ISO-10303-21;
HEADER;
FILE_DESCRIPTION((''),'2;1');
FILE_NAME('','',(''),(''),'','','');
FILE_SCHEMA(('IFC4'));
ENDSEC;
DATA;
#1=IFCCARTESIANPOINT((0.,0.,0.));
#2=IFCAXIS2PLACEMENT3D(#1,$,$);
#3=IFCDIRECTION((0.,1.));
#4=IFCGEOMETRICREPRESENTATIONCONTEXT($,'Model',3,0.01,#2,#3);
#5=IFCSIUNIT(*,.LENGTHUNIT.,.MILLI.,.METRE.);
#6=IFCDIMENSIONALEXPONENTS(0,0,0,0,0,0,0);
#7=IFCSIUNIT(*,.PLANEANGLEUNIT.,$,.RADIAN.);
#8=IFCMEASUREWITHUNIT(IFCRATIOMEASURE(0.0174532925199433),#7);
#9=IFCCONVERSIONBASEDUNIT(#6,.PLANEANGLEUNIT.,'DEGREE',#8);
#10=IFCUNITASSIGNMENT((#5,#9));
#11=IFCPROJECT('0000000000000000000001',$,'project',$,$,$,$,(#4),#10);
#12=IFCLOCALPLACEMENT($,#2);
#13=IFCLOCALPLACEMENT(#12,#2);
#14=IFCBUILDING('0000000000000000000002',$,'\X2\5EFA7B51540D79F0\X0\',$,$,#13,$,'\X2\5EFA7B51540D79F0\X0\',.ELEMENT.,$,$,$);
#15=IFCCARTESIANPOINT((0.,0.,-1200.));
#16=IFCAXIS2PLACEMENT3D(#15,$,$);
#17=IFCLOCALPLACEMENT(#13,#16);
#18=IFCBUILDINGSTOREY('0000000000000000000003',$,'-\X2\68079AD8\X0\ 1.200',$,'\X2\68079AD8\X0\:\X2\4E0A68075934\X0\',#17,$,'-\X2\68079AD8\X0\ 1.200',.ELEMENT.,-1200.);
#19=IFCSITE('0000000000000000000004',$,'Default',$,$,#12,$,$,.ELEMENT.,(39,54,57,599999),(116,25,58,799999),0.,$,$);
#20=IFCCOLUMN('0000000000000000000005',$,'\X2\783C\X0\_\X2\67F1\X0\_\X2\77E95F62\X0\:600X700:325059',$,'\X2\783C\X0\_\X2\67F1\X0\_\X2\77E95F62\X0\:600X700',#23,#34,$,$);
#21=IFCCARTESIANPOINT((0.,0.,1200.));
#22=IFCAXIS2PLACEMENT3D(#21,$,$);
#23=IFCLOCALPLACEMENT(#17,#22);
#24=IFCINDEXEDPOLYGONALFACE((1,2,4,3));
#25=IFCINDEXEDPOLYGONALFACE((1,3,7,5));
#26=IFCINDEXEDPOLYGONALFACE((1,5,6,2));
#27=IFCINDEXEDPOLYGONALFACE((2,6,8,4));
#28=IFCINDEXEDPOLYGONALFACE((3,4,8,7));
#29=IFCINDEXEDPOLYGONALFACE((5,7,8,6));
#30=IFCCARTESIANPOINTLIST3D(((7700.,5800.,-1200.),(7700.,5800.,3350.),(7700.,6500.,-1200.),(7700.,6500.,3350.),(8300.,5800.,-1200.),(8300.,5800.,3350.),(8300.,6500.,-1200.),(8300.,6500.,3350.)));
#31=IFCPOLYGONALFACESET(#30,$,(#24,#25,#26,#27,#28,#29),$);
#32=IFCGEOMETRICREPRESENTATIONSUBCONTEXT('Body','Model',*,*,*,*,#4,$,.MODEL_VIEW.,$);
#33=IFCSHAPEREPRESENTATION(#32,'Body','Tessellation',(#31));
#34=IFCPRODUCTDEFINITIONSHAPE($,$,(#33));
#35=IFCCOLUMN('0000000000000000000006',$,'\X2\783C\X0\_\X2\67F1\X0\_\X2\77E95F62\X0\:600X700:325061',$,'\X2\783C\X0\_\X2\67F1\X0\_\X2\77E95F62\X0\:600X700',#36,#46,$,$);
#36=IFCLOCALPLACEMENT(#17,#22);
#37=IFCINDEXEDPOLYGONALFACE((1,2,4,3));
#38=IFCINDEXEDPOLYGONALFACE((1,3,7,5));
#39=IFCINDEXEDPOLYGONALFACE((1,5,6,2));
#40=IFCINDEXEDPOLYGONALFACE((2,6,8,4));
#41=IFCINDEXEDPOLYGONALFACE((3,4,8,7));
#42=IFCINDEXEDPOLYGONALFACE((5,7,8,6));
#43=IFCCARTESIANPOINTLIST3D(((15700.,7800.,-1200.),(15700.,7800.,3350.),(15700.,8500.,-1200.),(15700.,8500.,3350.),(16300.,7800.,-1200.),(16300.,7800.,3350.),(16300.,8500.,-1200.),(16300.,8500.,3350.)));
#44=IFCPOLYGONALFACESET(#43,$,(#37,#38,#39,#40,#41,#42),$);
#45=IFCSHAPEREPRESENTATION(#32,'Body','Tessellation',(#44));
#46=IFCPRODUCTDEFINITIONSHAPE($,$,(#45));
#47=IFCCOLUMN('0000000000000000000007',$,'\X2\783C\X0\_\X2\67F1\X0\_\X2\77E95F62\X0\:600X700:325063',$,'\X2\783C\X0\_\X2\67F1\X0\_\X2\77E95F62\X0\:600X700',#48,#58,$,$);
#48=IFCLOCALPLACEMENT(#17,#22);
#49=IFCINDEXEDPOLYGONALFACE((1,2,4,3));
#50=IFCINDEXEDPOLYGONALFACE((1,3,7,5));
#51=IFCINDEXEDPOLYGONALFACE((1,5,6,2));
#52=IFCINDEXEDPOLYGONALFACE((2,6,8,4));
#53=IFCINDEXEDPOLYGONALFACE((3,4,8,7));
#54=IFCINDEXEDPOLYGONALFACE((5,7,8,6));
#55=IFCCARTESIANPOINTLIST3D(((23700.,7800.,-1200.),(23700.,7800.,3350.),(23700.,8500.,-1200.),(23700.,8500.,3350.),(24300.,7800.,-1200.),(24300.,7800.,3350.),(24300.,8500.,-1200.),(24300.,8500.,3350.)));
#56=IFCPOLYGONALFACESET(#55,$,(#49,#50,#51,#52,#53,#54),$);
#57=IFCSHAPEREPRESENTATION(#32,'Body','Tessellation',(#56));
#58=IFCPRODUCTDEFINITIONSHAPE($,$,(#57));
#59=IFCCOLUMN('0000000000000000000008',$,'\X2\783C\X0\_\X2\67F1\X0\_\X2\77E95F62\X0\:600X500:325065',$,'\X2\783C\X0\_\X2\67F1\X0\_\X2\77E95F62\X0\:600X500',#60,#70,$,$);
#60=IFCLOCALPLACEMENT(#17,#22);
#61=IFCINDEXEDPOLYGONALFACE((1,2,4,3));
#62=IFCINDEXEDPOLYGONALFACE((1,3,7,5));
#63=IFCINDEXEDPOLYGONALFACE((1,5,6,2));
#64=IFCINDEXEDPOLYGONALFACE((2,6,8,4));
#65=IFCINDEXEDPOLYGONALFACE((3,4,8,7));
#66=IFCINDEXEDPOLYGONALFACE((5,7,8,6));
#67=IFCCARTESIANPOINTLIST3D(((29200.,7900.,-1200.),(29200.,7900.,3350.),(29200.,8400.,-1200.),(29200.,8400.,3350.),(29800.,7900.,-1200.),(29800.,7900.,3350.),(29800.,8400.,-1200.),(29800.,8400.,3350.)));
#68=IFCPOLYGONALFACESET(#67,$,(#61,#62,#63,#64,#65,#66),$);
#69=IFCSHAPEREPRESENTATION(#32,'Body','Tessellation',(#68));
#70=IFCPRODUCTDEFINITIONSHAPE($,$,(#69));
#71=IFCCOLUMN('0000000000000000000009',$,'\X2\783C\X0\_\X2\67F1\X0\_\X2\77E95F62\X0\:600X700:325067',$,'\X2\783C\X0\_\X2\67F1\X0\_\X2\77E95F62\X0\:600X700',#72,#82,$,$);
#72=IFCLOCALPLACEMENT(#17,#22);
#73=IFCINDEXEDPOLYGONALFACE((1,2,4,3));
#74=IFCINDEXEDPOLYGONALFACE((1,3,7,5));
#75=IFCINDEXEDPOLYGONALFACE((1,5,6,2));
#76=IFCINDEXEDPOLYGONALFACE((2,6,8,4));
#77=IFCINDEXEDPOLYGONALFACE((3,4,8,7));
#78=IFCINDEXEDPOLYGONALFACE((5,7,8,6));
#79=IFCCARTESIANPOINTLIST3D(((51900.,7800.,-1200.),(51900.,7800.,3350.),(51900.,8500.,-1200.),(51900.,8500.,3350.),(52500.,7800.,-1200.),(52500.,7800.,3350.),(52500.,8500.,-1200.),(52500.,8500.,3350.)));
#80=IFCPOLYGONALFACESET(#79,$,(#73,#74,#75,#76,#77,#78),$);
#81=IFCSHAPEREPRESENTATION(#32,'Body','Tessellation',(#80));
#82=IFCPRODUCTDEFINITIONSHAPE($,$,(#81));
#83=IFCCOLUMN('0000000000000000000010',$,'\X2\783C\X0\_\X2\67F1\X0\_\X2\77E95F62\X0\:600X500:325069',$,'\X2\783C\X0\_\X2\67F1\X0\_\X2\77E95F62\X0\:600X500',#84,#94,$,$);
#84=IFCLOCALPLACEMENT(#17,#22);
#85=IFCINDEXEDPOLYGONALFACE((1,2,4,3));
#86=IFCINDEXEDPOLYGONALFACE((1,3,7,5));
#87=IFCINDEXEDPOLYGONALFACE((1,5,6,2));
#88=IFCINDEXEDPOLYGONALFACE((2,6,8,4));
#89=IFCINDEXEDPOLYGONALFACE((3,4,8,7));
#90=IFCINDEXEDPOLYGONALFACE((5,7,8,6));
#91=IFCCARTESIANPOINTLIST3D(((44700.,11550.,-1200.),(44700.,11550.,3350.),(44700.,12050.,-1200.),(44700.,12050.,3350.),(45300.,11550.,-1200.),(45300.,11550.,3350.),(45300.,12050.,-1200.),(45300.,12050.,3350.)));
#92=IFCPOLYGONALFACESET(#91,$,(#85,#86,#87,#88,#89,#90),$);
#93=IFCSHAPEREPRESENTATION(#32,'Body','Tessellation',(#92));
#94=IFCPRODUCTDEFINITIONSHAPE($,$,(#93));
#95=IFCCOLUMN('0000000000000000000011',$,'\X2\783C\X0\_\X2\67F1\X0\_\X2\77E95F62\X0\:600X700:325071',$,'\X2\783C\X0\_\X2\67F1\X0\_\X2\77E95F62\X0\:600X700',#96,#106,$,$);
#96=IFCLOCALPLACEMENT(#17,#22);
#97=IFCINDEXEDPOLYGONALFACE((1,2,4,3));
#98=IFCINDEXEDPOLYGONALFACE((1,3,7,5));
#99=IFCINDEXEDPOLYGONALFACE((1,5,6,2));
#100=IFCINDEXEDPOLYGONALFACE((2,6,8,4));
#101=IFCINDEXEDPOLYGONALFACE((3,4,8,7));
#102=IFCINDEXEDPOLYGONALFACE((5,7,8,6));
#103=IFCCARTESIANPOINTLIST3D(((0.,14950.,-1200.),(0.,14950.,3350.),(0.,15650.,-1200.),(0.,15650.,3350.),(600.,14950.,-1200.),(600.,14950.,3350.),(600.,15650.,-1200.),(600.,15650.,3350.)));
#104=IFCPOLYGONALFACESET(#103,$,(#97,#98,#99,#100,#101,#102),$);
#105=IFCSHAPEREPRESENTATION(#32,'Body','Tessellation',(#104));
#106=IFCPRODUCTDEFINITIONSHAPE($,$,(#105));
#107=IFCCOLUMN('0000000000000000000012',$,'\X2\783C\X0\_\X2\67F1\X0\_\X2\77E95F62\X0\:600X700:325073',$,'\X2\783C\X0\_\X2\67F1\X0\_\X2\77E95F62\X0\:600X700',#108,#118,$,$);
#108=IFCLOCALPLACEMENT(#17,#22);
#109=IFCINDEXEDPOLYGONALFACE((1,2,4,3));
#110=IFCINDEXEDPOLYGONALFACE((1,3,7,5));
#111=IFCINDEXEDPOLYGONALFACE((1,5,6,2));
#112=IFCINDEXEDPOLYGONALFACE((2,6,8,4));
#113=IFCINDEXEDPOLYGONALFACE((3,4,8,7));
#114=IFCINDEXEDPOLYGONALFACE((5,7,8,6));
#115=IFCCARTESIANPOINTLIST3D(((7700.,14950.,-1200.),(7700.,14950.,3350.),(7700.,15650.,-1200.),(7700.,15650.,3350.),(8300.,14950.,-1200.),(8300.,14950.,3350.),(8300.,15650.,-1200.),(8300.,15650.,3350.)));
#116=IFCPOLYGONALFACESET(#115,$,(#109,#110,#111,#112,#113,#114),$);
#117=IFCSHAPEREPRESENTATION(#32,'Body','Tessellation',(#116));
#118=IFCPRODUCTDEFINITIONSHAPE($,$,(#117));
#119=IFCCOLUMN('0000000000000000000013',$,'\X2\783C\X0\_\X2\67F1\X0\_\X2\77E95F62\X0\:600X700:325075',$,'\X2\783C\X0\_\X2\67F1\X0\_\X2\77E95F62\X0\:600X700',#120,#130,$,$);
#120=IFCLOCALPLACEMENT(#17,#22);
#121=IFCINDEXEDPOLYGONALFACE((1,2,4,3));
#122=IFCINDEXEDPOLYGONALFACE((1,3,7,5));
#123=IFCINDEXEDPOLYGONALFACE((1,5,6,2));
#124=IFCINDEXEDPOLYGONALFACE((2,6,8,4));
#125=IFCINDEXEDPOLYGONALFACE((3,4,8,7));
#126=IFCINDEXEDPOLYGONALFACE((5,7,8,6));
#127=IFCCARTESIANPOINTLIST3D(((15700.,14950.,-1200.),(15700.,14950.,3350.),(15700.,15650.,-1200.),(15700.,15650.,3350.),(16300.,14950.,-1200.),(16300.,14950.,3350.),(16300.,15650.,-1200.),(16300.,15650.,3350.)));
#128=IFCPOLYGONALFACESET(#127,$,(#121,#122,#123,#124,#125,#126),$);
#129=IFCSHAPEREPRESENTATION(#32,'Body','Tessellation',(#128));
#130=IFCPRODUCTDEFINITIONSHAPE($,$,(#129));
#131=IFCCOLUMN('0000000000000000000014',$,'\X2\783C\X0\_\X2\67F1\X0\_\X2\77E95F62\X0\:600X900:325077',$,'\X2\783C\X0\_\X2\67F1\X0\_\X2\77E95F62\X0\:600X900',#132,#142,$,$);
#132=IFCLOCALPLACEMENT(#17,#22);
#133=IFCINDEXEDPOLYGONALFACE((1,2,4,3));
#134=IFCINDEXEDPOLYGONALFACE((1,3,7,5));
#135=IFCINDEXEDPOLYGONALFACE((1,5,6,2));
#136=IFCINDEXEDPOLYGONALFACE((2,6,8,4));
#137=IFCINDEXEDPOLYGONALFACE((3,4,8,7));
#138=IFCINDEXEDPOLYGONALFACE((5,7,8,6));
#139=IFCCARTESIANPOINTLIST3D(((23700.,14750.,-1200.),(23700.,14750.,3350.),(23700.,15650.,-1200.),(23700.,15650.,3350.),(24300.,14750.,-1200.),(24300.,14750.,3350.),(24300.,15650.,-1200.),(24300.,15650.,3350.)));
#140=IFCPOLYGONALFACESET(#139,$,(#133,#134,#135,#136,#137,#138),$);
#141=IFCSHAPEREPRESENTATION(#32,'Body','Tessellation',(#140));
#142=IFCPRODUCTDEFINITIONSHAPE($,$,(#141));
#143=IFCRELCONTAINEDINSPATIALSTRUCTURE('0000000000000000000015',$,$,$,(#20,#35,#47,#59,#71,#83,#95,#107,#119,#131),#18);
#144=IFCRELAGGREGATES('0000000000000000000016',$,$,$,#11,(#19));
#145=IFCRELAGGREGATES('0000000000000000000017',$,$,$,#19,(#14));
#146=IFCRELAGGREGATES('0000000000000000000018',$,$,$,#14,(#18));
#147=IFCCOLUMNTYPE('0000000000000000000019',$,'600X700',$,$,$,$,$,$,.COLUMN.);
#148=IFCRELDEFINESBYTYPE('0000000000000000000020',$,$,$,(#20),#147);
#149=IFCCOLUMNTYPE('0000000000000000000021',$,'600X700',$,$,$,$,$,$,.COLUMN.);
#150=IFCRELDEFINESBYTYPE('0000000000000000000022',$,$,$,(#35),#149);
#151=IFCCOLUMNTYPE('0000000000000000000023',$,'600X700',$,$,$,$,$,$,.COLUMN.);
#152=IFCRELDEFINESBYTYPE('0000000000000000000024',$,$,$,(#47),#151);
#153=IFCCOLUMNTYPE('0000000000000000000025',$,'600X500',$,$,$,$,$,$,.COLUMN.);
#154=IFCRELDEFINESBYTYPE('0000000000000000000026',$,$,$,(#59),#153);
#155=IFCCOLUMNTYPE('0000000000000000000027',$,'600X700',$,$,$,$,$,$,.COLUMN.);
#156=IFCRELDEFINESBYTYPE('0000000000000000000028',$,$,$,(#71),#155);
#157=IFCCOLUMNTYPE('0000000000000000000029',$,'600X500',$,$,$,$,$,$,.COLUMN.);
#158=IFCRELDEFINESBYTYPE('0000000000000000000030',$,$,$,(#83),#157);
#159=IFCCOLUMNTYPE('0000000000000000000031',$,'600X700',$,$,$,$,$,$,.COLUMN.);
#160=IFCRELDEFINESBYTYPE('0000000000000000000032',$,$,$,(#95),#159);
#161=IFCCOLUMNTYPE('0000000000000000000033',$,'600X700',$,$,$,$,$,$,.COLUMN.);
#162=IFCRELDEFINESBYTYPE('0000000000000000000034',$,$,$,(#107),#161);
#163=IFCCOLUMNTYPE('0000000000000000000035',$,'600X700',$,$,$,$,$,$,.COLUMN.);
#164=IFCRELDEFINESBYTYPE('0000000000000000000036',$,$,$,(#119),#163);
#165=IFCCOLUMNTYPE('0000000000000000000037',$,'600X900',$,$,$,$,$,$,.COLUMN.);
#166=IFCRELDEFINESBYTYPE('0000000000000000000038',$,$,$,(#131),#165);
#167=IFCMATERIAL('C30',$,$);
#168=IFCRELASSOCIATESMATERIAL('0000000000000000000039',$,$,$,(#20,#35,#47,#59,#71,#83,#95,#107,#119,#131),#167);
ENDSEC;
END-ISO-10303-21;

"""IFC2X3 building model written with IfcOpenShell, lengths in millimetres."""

from ifc_helpers import new_model, entity, si_unit, converted_unit, direction, frame, frame_2d, origin, origin_2d_with_axis, place, context, subcontext, project, spatial, rectangle, extrude, source, transform, mapped, material, type_object, type_shapes, element, save


model = new_model("IFC2X3")

# Units and contexts
model_context = context("Model", 3, precision=0.01, world=origin(), true_north=direction((0.0, 1.0)))
body_context = subcontext(model_context, "Body", "Model", "MODEL_VIEW")
ifc_project = project(units=[si_unit("LENGTHUNIT", "METRE", prefix="MILLI"), converted_unit("PLANEANGLEUNIT", "DEGREE", entity("IfcRatioMeasure", 0.0174532925199433), si_unit("PLANEANGLEUNIT", "RADIAN"), dimensions=[0, 0, 0, 0, 0, 0, 0])], contexts=[model_context])

# Site, building, storey
site_placement = place(None, origin())
site = spatial("IfcSite", under=ifc_project, at=site_placement, Name="Default", CompositionType="ELEMENT", RefLatitude=(39, 54, 57, 599999), RefLongitude=(116, 25, 58, 799999), RefElevation=0.0)
building_placement = place(site_placement, origin())
building = spatial("IfcBuilding", under=site, at=building_placement, Name="建筑名称", LongName="建筑名称", CompositionType="ELEMENT")
storey_placement = place(building_placement, frame((0.0, 0.0, -1200.0)))
storey = spatial("IfcBuildingStorey", under=building, at=storey_placement, Name="-标高 1.200", ObjectType="标高:上标头", LongName="-标高 1.200", CompositionType="ELEMENT", Elevation=-1200.0)

# Columns
ifc_material = material(Name="C30")
column_type_1 = type_object("IfcColumnType", Name="600X700", PredefinedType="COLUMN")
shared_shape_1 = source(origin(), body_context, "Body", "SweptSolid", [
    extrude(rectangle(XDim=700.0, YDim=600.0, at=origin_2d_with_axis()), frame((8000.0, 6150.0, -1200.0), z_axis=(0.0, 0.0, 1.0), x_axis=(0.0, -1.0, 0.0)), (0.0, 0.0, 1.0), 4550.0),
])
type_shapes(column_type_1, [shared_shape_1])
column_1_placement = place(storey_placement, frame((0.0, 0.0, 1200.0)))
element("IfcColumn", 1, at=column_1_placement, inside=storey, type_object=column_type_1, material=ifc_material, Name="砼_柱_矩形:600X700:325059", ObjectType="砼_柱_矩形:600X700", context=body_context, shape_type="MappedRepresentation", body=[
    mapped(shared_shape_1, transform((0.0, 0.0, 0.0), scale=1.0)),
])
column_type_2 = type_object("IfcColumnType", Name="600X700", PredefinedType="COLUMN")
shared_shape_2 = source(origin(), body_context, "Body", "SweptSolid", [
    extrude(rectangle(XDim=700.0, YDim=600.0, at=frame_2d((0.0, 0.0), x_axis=(1.0, 0.0))), frame((16000.0, 8150.0, -1200.0), z_axis=(0.0, 0.0, 1.0), x_axis=(0.0, -1.0, 0.0)), (0.0, 0.0, 1.0), 4550.0),
])
type_shapes(column_type_2, [shared_shape_2])
column_2_placement = place(storey_placement, frame((0.0, 0.0, 1200.0)))
element("IfcColumn", 2, at=column_2_placement, inside=storey, type_object=column_type_2, material=ifc_material, Name="砼_柱_矩形:600X700:325061", ObjectType="砼_柱_矩形:600X700", context=body_context, shape_type="MappedRepresentation", body=[
    mapped(shared_shape_2, transform((0.0, 0.0, 0.0), scale=1.0)),
])
column_type_3 = type_object("IfcColumnType", Name="600X700", PredefinedType="COLUMN")
shared_shape_3 = source(origin(), body_context, "Body", "SweptSolid", [
    extrude(rectangle(XDim=700.0, YDim=600.0, at=origin_2d_with_axis()), frame((24000.0, 8150.0, -1200.0), z_axis=(0.0, 0.0, 1.0), x_axis=(0.0, -1.0, 0.0)), (0.0, 0.0, 1.0), 4550.0),
])
type_shapes(column_type_3, [shared_shape_3])
column_3_placement = place(storey_placement, frame((0.0, 0.0, 1200.0)))
element("IfcColumn", 3, at=column_3_placement, inside=storey, type_object=column_type_3, material=ifc_material, Name="砼_柱_矩形:600X700:325063", ObjectType="砼_柱_矩形:600X700", context=body_context, shape_type="MappedRepresentation", body=[
    mapped(shared_shape_3, transform((0.0, 0.0, 0.0), scale=1.0)),
])
column_type_4 = type_object("IfcColumnType", Name="600X500", PredefinedType="COLUMN")
shared_shape_4 = source(origin(), body_context, "Body", "SweptSolid", [
    extrude(rectangle(XDim=500.0, YDim=600.0, at=frame_2d((0.0, 0.0), x_axis=(1.0, 0.0))), frame((29500.0, 8150.0, -1200.0), z_axis=(0.0, 0.0, 1.0), x_axis=(0.0, -1.0, 0.0)), (0.0, 0.0, 1.0), 4550.0),
])
type_shapes(column_type_4, [shared_shape_4])
column_4_placement = place(storey_placement, frame((0.0, 0.0, 1200.0)))
element("IfcColumn", 4, at=column_4_placement, inside=storey, type_object=column_type_4, material=ifc_material, Name="砼_柱_矩形:600X500:325065", ObjectType="砼_柱_矩形:600X500", context=body_context, shape_type="MappedRepresentation", body=[
    mapped(shared_shape_4, transform((0.0, 0.0, 0.0), scale=1.0)),
])
column_type_5 = type_object("IfcColumnType", Name="600X700", PredefinedType="COLUMN")
shared_shape_5 = source(origin(), body_context, "Body", "SweptSolid", [
    extrude(rectangle(XDim=700.0, YDim=600.0, at=origin_2d_with_axis()), frame((52200.0, 8150.0, -1200.0), z_axis=(0.0, 0.0, 1.0), x_axis=(0.0, -1.0, 0.0)), (0.0, 0.0, 1.0), 4550.0),
])
type_shapes(column_type_5, [shared_shape_5])
column_5_placement = place(storey_placement, frame((0.0, 0.0, 1200.0)))
element("IfcColumn", 5, at=column_5_placement, inside=storey, type_object=column_type_5, material=ifc_material, Name="砼_柱_矩形:600X700:325067", ObjectType="砼_柱_矩形:600X700", context=body_context, shape_type="MappedRepresentation", body=[
    mapped(shared_shape_5, transform((0.0, 0.0, 0.0), scale=1.0)),
])
column_type_6 = type_object("IfcColumnType", Name="600X500", PredefinedType="COLUMN")
shared_shape_6 = source(origin(), body_context, "Body", "SweptSolid", [
    extrude(rectangle(XDim=500.0, YDim=600.0, at=origin_2d_with_axis()), frame((45000.0, 11800.0, -1200.0), z_axis=(0.0, 0.0, 1.0), x_axis=(0.0, -1.0, 0.0)), (0.0, 0.0, 1.0), 4550.0),
])
type_shapes(column_type_6, [shared_shape_6])
column_6_placement = place(storey_placement, frame((0.0, 0.0, 1200.0)))
element("IfcColumn", 6, at=column_6_placement, inside=storey, type_object=column_type_6, material=ifc_material, Name="砼_柱_矩形:600X500:325069", ObjectType="砼_柱_矩形:600X500", context=body_context, shape_type="MappedRepresentation", body=[
    mapped(shared_shape_6, transform((0.0, 0.0, 0.0), scale=1.0)),
])
column_type_7 = type_object("IfcColumnType", Name="600X700", PredefinedType="COLUMN")
shared_shape_7 = source(origin(), body_context, "Body", "SweptSolid", [
    extrude(rectangle(XDim=700.0, YDim=600.0, at=origin_2d_with_axis()), frame((300.0, 15300.0, -1200.0), z_axis=(0.0, 0.0, 1.0), x_axis=(0.0, -1.0, 0.0)), (0.0, 0.0, 1.0), 4550.0),
])
type_shapes(column_type_7, [shared_shape_7])
column_7_placement = place(storey_placement, frame((0.0, 0.0, 1200.0)))
element("IfcColumn", 7, at=column_7_placement, inside=storey, type_object=column_type_7, material=ifc_material, Name="砼_柱_矩形:600X700:325071", ObjectType="砼_柱_矩形:600X700", context=body_context, shape_type="MappedRepresentation", body=[
    mapped(shared_shape_7, transform((0.0, 0.0, 0.0), scale=1.0)),
])
column_type_8 = type_object("IfcColumnType", Name="600X700", PredefinedType="COLUMN")
shared_shape_8 = source(origin(), body_context, "Body", "SweptSolid", [
    extrude(rectangle(XDim=700.0, YDim=600.0, at=origin_2d_with_axis()), frame((8000.0, 15300.0, -1200.0), z_axis=(0.0, 0.0, 1.0), x_axis=(0.0, -1.0, 0.0)), (0.0, 0.0, 1.0), 4550.0),
])
type_shapes(column_type_8, [shared_shape_8])
column_8_placement = place(storey_placement, frame((0.0, 0.0, 1200.0)))
element("IfcColumn", 8, at=column_8_placement, inside=storey, type_object=column_type_8, material=ifc_material, Name="砼_柱_矩形:600X700:325073", ObjectType="砼_柱_矩形:600X700", context=body_context, shape_type="MappedRepresentation", body=[
    mapped(shared_shape_8, transform((0.0, 0.0, 0.0), scale=1.0)),
])
column_type_9 = type_object("IfcColumnType", Name="600X700", PredefinedType="COLUMN")
shared_shape_9 = source(origin(), body_context, "Body", "SweptSolid", [
    extrude(rectangle(XDim=700.0, YDim=600.0, at=frame_2d((0.0, 0.0), x_axis=(1.0, 0.0))), frame((16000.0, 15300.0, -1200.0), z_axis=(0.0, 0.0, 1.0), x_axis=(0.0, -1.0, 0.0)), (0.0, 0.0, 1.0), 4550.0),
])
type_shapes(column_type_9, [shared_shape_9])
column_9_placement = place(storey_placement, frame((0.0, 0.0, 1200.0)))
element("IfcColumn", 9, at=column_9_placement, inside=storey, type_object=column_type_9, material=ifc_material, Name="砼_柱_矩形:600X700:325075", ObjectType="砼_柱_矩形:600X700", context=body_context, shape_type="MappedRepresentation", body=[
    mapped(shared_shape_9, transform((0.0, 0.0, 0.0), scale=1.0)),
])
column_type_10 = type_object("IfcColumnType", Name="600X900", PredefinedType="COLUMN")
shared_shape_10 = source(origin(), body_context, "Body", "SweptSolid", [
    extrude(rectangle(XDim=900.0, YDim=600.0, at=origin_2d_with_axis()), frame((24000.0, 15200.0, -1200.0), z_axis=(0.0, 0.0, 1.0), x_axis=(0.0, -1.0, 0.0)), (0.0, 0.0, 1.0), 4550.0),
])
type_shapes(column_type_10, [shared_shape_10])
column_10_placement = place(storey_placement, frame((0.0, 0.0, 1200.0)))
element("IfcColumn", 10, at=column_10_placement, inside=storey, type_object=column_type_10, material=ifc_material, Name="砼_柱_矩形:600X900:325077", ObjectType="砼_柱_矩形:600X900", context=body_context, shape_type="MappedRepresentation", body=[
    mapped(shared_shape_10, transform((0.0, 0.0, 0.0), scale=1.0)),
])

save(model, "model.ifc")
